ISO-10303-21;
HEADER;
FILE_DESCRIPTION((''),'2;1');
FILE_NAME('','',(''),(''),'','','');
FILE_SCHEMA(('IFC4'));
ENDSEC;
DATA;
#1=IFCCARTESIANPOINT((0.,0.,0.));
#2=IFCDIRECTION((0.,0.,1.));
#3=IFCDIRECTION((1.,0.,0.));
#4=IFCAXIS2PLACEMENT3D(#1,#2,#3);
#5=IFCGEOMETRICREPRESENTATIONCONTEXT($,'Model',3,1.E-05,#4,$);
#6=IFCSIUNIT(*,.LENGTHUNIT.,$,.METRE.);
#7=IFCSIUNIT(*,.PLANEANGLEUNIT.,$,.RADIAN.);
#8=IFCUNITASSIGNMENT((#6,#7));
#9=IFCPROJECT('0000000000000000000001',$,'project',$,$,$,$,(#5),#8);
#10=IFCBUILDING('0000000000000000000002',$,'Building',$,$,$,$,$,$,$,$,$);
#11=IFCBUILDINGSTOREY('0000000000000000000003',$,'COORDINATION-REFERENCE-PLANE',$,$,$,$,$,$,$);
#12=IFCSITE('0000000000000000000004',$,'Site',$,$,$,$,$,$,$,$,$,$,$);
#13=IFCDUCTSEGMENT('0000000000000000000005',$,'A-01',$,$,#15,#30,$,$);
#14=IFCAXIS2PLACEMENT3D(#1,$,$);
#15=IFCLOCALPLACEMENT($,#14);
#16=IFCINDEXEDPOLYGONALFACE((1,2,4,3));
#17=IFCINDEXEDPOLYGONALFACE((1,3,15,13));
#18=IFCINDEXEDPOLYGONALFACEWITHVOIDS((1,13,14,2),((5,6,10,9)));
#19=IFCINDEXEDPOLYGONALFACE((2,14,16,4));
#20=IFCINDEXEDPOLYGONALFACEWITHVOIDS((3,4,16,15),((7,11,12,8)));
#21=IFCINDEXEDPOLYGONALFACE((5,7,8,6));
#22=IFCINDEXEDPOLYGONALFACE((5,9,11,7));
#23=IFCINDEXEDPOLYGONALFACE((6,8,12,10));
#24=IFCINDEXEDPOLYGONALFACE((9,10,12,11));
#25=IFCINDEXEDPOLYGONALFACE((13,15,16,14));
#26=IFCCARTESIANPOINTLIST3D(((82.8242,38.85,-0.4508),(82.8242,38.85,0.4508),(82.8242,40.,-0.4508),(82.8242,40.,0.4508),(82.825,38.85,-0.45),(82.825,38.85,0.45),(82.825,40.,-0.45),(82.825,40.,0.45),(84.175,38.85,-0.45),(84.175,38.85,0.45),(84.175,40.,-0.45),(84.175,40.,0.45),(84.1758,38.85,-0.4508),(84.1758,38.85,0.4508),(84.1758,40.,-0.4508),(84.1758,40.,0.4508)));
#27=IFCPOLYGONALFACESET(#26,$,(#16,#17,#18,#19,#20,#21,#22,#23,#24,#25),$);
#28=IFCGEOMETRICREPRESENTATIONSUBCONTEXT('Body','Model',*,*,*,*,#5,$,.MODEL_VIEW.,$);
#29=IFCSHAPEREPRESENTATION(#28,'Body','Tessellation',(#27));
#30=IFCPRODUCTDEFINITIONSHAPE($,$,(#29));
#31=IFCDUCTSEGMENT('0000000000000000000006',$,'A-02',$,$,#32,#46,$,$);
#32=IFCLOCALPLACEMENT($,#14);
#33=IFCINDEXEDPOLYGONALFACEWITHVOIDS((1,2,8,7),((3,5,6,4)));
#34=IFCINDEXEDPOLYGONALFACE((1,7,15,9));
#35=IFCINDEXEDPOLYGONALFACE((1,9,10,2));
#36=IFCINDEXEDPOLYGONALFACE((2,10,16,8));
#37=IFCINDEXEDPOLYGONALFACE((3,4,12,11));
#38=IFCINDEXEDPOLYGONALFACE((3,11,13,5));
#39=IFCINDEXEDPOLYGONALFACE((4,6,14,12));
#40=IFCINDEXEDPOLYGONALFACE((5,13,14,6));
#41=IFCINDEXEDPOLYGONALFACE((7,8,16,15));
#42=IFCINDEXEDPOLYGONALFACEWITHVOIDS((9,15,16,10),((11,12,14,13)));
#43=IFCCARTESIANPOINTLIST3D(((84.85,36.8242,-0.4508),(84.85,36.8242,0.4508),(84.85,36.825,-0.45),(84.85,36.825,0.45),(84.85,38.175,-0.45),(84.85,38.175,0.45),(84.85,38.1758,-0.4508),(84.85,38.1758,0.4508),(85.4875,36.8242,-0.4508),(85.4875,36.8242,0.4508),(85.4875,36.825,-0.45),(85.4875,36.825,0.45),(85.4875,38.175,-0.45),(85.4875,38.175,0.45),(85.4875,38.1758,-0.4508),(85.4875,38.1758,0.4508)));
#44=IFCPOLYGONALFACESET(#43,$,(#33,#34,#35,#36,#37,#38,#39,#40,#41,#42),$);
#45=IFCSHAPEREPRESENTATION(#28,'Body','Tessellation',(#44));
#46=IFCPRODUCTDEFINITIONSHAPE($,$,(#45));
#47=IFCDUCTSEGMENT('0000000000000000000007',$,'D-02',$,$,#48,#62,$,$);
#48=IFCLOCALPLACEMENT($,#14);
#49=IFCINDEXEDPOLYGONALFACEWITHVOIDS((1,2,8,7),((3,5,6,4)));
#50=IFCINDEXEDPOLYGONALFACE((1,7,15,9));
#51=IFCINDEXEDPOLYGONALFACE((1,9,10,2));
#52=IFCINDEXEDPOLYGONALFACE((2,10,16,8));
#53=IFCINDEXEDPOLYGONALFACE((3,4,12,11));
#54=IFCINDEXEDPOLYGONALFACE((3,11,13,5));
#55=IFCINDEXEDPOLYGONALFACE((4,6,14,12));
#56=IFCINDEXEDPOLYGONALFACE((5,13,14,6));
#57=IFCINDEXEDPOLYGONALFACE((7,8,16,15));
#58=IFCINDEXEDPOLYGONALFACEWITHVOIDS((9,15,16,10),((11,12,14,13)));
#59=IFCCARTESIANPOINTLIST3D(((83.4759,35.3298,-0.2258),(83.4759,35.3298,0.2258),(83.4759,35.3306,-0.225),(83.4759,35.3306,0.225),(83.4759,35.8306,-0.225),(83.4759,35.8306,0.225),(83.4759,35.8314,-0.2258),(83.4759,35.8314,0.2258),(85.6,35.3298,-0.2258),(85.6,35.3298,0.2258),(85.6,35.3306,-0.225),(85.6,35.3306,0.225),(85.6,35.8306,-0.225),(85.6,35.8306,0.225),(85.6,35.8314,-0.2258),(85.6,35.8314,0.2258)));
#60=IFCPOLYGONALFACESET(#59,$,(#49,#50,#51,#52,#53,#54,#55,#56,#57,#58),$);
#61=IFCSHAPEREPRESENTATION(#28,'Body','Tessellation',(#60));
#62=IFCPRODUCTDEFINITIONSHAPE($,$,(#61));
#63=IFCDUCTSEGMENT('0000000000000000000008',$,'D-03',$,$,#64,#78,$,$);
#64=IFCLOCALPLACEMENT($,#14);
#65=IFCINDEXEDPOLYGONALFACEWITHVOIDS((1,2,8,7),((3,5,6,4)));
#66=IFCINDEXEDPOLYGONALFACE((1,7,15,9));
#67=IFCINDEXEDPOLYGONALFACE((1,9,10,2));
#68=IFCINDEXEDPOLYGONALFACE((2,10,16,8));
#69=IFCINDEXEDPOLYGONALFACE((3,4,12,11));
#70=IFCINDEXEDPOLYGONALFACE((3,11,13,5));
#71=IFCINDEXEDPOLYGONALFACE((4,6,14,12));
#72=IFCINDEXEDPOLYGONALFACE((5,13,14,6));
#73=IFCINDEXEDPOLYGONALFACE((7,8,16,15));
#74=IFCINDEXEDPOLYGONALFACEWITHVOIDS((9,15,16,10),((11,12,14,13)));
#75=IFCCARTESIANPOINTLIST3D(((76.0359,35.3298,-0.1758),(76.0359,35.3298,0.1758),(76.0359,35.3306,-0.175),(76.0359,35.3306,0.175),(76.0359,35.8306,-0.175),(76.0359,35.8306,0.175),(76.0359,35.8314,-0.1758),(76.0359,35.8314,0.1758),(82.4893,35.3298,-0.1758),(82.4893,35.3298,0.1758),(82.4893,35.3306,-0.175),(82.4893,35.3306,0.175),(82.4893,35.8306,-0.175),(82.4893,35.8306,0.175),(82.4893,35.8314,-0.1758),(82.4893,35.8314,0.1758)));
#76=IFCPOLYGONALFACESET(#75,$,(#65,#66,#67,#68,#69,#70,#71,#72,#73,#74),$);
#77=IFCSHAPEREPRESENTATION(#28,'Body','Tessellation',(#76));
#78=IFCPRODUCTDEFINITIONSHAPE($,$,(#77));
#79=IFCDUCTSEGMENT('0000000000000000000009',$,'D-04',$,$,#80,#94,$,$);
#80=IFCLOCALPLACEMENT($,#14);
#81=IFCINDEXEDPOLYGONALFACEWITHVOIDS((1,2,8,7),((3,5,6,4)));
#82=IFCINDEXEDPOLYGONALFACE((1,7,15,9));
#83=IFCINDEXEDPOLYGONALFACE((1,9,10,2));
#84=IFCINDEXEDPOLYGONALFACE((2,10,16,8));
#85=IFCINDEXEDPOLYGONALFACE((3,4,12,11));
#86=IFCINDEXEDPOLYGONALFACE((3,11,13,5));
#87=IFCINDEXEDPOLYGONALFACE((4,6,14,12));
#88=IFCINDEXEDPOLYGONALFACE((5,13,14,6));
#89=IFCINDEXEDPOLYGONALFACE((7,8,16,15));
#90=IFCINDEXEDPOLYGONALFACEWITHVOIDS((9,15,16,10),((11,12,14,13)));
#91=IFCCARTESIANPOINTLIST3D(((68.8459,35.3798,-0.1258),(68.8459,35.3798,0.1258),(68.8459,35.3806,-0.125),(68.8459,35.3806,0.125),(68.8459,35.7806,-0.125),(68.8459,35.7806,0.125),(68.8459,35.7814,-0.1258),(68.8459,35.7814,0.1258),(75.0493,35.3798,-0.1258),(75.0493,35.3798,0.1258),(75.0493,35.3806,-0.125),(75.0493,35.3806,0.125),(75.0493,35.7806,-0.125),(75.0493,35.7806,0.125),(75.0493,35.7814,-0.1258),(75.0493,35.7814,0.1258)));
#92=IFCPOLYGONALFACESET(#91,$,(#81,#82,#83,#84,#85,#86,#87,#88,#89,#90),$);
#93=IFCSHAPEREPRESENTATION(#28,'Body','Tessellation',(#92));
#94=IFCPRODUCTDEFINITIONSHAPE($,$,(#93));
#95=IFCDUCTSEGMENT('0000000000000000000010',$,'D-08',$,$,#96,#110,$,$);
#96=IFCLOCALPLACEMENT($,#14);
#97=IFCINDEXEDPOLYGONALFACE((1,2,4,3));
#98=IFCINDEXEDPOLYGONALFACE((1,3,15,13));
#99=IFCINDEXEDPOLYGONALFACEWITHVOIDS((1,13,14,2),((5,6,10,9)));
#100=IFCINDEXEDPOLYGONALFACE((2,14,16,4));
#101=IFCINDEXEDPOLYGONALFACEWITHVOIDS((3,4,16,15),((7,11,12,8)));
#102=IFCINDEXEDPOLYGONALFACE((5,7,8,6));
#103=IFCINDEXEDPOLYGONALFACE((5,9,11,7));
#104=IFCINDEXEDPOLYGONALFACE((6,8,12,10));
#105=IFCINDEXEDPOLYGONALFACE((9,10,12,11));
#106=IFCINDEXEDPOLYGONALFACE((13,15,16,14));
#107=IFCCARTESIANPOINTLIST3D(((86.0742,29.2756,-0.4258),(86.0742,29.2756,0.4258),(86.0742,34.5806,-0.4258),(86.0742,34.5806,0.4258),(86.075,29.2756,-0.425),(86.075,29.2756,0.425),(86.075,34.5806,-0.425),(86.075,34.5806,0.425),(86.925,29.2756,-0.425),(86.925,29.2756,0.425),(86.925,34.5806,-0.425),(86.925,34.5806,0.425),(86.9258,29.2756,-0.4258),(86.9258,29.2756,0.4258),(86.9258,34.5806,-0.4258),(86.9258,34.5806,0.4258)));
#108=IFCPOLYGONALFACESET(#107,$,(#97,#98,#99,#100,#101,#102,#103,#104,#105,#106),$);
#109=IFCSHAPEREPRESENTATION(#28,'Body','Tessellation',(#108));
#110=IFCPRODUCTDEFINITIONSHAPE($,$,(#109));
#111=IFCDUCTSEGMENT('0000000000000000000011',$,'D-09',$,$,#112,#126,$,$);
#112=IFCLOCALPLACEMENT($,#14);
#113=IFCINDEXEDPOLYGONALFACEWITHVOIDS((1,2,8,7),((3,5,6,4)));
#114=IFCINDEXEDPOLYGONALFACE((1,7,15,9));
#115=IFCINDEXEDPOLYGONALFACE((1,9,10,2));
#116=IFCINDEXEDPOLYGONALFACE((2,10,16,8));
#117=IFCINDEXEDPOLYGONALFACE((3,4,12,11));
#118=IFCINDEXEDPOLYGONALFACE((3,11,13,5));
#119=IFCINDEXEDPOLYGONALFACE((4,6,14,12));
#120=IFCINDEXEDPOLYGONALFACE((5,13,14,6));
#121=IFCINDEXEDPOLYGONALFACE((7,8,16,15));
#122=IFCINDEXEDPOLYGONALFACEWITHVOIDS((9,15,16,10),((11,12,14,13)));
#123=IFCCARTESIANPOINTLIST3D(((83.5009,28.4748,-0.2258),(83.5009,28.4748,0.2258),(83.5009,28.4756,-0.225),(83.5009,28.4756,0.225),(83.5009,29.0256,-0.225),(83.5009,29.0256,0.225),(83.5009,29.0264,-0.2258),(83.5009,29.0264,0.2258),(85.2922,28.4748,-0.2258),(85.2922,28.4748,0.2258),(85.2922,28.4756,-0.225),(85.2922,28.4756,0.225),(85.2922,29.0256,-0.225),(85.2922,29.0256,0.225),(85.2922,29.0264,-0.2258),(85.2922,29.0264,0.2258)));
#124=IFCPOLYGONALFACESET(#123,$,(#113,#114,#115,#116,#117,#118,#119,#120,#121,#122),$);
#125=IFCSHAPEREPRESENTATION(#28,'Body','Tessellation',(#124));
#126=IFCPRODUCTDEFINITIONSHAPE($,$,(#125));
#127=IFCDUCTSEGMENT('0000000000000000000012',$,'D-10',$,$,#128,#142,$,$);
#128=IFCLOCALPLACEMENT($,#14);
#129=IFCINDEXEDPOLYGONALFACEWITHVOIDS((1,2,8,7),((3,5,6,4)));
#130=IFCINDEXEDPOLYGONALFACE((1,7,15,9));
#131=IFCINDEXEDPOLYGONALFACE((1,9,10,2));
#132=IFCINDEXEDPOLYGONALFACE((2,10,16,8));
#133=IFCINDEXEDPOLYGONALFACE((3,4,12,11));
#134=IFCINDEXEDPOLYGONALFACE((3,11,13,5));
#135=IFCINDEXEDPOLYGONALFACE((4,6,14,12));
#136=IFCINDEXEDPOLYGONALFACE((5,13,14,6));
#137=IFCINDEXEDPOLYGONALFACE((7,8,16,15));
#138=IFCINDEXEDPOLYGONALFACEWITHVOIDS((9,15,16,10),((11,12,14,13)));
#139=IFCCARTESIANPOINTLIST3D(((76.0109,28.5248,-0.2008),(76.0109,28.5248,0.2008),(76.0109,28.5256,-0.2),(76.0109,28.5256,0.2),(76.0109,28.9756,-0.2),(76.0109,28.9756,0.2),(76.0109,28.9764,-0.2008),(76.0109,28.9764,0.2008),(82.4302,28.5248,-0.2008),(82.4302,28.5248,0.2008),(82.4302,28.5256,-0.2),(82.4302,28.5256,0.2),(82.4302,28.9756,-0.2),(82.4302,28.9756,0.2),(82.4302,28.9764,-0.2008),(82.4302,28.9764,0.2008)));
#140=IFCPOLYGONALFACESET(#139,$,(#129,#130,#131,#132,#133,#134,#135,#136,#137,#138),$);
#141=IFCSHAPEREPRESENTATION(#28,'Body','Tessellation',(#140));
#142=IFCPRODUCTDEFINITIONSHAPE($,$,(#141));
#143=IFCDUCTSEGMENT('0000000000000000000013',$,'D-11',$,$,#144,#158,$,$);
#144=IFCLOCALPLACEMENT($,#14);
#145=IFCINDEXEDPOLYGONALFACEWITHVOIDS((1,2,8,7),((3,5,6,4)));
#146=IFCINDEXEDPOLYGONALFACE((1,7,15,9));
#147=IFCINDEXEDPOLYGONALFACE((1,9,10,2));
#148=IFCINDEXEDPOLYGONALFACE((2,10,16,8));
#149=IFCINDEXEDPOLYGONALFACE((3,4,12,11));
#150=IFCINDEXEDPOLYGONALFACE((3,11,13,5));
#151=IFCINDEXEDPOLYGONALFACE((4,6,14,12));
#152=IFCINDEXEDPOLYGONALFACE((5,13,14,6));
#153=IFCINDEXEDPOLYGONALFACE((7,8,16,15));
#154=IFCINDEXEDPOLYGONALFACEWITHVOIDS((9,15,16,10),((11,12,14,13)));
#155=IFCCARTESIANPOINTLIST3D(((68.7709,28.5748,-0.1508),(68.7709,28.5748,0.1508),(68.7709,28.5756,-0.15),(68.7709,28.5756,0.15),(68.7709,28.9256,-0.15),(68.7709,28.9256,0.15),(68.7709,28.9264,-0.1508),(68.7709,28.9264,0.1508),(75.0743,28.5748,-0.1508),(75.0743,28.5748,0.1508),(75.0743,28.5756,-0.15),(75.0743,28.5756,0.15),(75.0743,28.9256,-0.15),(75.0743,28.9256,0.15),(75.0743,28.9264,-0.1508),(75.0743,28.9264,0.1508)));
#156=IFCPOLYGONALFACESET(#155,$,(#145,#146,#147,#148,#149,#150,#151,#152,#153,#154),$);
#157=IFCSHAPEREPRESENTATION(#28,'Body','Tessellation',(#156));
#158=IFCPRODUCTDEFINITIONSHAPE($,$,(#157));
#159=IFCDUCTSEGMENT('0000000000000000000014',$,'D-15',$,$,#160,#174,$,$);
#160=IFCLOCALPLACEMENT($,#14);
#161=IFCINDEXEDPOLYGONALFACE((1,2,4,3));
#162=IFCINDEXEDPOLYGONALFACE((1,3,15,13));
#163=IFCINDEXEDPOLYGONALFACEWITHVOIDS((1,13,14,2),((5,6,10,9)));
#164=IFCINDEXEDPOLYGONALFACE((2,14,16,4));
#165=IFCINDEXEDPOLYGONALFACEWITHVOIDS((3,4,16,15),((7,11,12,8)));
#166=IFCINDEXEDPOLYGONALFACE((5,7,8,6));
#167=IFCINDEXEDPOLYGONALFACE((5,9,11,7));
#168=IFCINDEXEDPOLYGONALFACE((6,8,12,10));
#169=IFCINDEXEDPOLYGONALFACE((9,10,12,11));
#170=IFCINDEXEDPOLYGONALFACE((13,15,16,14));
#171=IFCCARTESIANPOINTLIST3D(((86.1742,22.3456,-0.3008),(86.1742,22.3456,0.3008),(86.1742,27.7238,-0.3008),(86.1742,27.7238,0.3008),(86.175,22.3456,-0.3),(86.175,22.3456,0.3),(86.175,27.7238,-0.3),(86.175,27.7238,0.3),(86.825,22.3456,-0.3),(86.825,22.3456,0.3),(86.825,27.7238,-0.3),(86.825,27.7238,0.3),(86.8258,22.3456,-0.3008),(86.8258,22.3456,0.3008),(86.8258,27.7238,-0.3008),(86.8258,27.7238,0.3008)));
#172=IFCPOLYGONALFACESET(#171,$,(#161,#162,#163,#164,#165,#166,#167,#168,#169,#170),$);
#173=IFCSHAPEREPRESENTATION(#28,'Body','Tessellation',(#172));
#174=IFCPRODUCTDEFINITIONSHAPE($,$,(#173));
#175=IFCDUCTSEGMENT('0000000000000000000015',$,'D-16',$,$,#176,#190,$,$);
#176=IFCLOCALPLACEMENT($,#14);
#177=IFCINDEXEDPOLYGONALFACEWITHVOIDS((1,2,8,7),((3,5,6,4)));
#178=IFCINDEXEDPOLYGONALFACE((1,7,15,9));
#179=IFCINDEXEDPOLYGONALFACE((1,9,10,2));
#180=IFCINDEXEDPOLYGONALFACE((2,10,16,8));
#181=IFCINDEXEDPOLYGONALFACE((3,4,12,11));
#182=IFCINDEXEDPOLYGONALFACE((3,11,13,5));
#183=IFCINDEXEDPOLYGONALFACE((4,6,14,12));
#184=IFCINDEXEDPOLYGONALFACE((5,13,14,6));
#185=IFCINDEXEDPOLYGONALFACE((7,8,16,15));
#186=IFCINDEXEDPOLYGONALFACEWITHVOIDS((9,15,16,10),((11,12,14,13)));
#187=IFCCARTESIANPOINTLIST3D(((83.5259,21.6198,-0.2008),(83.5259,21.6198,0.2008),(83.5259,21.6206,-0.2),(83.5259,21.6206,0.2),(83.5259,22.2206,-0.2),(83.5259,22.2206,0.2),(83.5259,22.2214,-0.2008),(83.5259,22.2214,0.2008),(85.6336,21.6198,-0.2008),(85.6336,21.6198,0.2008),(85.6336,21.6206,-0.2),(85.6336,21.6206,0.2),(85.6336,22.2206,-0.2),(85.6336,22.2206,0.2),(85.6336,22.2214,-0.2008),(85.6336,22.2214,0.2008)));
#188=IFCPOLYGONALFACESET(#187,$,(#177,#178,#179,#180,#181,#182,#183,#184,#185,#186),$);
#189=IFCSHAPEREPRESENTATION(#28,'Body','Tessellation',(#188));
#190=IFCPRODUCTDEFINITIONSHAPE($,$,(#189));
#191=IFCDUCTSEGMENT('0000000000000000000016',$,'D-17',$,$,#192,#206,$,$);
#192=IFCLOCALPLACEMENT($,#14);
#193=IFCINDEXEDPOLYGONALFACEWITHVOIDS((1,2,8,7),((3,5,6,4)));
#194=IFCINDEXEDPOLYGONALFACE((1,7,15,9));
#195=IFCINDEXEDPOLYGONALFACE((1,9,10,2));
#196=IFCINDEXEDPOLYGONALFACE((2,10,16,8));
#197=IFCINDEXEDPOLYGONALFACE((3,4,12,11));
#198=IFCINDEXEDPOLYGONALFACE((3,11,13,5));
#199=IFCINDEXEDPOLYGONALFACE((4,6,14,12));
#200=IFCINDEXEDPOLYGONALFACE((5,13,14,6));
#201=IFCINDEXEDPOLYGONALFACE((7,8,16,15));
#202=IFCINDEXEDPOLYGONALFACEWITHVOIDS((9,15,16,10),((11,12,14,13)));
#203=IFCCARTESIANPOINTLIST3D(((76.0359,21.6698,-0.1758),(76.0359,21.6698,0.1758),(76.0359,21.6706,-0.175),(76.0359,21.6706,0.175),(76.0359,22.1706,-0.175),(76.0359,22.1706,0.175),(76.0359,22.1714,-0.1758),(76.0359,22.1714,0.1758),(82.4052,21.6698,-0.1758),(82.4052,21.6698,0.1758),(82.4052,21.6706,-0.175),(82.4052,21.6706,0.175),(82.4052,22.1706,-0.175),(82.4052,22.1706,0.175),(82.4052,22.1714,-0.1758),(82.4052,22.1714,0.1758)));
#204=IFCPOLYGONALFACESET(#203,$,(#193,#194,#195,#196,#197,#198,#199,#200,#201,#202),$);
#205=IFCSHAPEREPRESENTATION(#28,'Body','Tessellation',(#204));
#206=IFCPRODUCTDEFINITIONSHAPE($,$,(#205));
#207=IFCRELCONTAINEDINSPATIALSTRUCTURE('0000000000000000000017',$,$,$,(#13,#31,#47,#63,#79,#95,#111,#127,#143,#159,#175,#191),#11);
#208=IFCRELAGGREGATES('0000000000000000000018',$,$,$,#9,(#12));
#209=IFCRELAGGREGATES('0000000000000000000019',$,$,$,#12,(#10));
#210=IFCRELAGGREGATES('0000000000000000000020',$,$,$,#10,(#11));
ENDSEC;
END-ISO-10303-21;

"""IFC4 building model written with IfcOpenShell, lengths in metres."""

from ifc_helpers import new_model, si_unit, frame, origin, origin_with_axes, place, context, subcontext, project, spatial, hollow_rectangle, extrude, element, save


model = new_model("IFC4")

# Units and contexts
model_context = context("Model", 3, precision=1e-05, world=origin_with_axes())
body_context = subcontext(model_context, "Body", "Model", "MODEL_VIEW")
ifc_project = project(units=[si_unit("LENGTHUNIT", "METRE"), si_unit("PLANEANGLEUNIT", "RADIAN")], contexts=[model_context])

# Site, building, storey
site = spatial("IfcSite", under=ifc_project, Name="Site")
building = spatial("IfcBuilding", under=site, Name="Building")
storey = spatial("IfcBuildingStorey", under=building, Name="COORDINATION-REFERENCE-PLANE")

# Duct segments
duct_segment_1_placement = place(None, frame((83.5, 38.85, 0.0), z_axis=(0.0, 1.0, 0.0), x_axis=(1.0, 0.0, 0.0)))
element("IfcDuctSegment", 1, at=duct_segment_1_placement, inside=storey, Name="A-01", context=body_context, shape_type="SweptSolid", body=[
    extrude(hollow_rectangle(XDim=1.3516, YDim=0.9016, WallThickness=0.0008), origin(), (0.0, 0.0, 1.0), 1.15),
])
duct_segment_2_placement = place(None, frame((84.85, 37.5, 0.0), z_axis=(1.0, 0.0, 0.0), x_axis=(0.0, 1.0, 0.0)))
element("IfcDuctSegment", 2, at=duct_segment_2_placement, inside=storey, Name="A-02", context=body_context, shape_type="SweptSolid", body=[
    extrude(hollow_rectangle(XDim=1.3516, YDim=0.9016, WallThickness=0.0008), origin(), (0.0, 0.0, 1.0), 0.6375),
])
duct_segment_3_placement = place(None, frame((83.4759, 35.5806, 0.0), z_axis=(1.0, 0.0, 0.0), x_axis=(0.0, 1.0, 0.0)))
element("IfcDuctSegment", 3, at=duct_segment_3_placement, inside=storey, Name="D-02", context=body_context, shape_type="SweptSolid", body=[
    extrude(hollow_rectangle(XDim=0.5016, YDim=0.4516, WallThickness=0.0008), origin(), (0.0, 0.0, 1.0), 2.1241),
])
duct_segment_4_placement = place(None, frame((76.0359, 35.5806, 0.0), z_axis=(1.0, 0.0, 0.0), x_axis=(0.0, 1.0, 0.0)))
element("IfcDuctSegment", 4, at=duct_segment_4_placement, inside=storey, Name="D-03", context=body_context, shape_type="SweptSolid", body=[
    extrude(hollow_rectangle(XDim=0.5016, YDim=0.3516, WallThickness=0.0008), origin(), (0.0, 0.0, 1.0), 6.4534),
])
duct_segment_5_placement = place(None, frame((68.8459, 35.5806, 0.0), z_axis=(1.0, 0.0, 0.0), x_axis=(0.0, 1.0, 0.0)))
element("IfcDuctSegment", 5, at=duct_segment_5_placement, inside=storey, Name="D-04", context=body_context, shape_type="SweptSolid", body=[
    extrude(hollow_rectangle(XDim=0.4016, YDim=0.2516, WallThickness=0.0008), origin(), (0.0, 0.0, 1.0), 6.2034),
])
duct_segment_6_placement = place(None, frame((86.5, 29.2756, 0.0), z_axis=(0.0, 1.0, 0.0), x_axis=(1.0, 0.0, 0.0)))
element("IfcDuctSegment", 6, at=duct_segment_6_placement, inside=storey, Name="D-08", context=body_context, shape_type="SweptSolid", body=[
    extrude(hollow_rectangle(XDim=0.8516, YDim=0.8516, WallThickness=0.0008), origin(), (0.0, 0.0, 1.0), 5.305),
])
duct_segment_7_placement = place(None, frame((83.5009, 28.7506, 0.0), z_axis=(1.0, 0.0, 0.0), x_axis=(0.0, 1.0, 0.0)))
element("IfcDuctSegment", 7, at=duct_segment_7_placement, inside=storey, Name="D-09", context=body_context, shape_type="SweptSolid", body=[
    extrude(hollow_rectangle(XDim=0.5516, YDim=0.4516, WallThickness=0.0008), origin(), (0.0, 0.0, 1.0), 1.7912),
])
duct_segment_8_placement = place(None, frame((76.0109, 28.7506, 0.0), z_axis=(1.0, 0.0, 0.0), x_axis=(0.0, 1.0, 0.0)))
element("IfcDuctSegment", 8, at=duct_segment_8_placement, inside=storey, Name="D-10", context=body_context, shape_type="SweptSolid", body=[
    extrude(hollow_rectangle(XDim=0.4516, YDim=0.4016, WallThickness=0.0008), origin(), (0.0, 0.0, 1.0), 6.4193),
])
duct_segment_9_placement = place(None, frame((68.7709, 28.7506, 0.0), z_axis=(1.0, 0.0, 0.0), x_axis=(0.0, 1.0, 0.0)))
element("IfcDuctSegment", 9, at=duct_segment_9_placement, inside=storey, Name="D-11", context=body_context, shape_type="SweptSolid", body=[
    extrude(hollow_rectangle(XDim=0.3516, YDim=0.3016, WallThickness=0.0008), origin(), (0.0, 0.0, 1.0), 6.3034),
])
duct_segment_10_placement = place(None, frame((86.5, 22.3456, 0.0), z_axis=(0.0, 1.0, 0.0), x_axis=(1.0, 0.0, 0.0)))
element("IfcDuctSegment", 10, at=duct_segment_10_placement, inside=storey, Name="D-15", context=body_context, shape_type="SweptSolid", body=[
    extrude(hollow_rectangle(XDim=0.6516, YDim=0.6016, WallThickness=0.0008), origin(), (0.0, 0.0, 1.0), 5.3782),
])
duct_segment_11_placement = place(None, frame((83.5259, 21.9206, 0.0), z_axis=(1.0, 0.0, 0.0), x_axis=(0.0, 1.0, 0.0)))
element("IfcDuctSegment", 11, at=duct_segment_11_placement, inside=storey, Name="D-16", context=body_context, shape_type="SweptSolid", body=[
    extrude(hollow_rectangle(XDim=0.6016, YDim=0.4016, WallThickness=0.0008), origin(), (0.0, 0.0, 1.0), 2.1076),
])
duct_segment_12_placement = place(None, frame((76.0359, 21.9206, 0.0), z_axis=(1.0, 0.0, 0.0), x_axis=(0.0, 1.0, 0.0)))
element("IfcDuctSegment", 12, at=duct_segment_12_placement, inside=storey, Name="D-17", context=body_context, shape_type="SweptSolid", body=[
    extrude(hollow_rectangle(XDim=0.5016, YDim=0.3516, WallThickness=0.0008), origin(), (0.0, 0.0, 1.0), 6.3693),
])

save(model, "model.ifc")
